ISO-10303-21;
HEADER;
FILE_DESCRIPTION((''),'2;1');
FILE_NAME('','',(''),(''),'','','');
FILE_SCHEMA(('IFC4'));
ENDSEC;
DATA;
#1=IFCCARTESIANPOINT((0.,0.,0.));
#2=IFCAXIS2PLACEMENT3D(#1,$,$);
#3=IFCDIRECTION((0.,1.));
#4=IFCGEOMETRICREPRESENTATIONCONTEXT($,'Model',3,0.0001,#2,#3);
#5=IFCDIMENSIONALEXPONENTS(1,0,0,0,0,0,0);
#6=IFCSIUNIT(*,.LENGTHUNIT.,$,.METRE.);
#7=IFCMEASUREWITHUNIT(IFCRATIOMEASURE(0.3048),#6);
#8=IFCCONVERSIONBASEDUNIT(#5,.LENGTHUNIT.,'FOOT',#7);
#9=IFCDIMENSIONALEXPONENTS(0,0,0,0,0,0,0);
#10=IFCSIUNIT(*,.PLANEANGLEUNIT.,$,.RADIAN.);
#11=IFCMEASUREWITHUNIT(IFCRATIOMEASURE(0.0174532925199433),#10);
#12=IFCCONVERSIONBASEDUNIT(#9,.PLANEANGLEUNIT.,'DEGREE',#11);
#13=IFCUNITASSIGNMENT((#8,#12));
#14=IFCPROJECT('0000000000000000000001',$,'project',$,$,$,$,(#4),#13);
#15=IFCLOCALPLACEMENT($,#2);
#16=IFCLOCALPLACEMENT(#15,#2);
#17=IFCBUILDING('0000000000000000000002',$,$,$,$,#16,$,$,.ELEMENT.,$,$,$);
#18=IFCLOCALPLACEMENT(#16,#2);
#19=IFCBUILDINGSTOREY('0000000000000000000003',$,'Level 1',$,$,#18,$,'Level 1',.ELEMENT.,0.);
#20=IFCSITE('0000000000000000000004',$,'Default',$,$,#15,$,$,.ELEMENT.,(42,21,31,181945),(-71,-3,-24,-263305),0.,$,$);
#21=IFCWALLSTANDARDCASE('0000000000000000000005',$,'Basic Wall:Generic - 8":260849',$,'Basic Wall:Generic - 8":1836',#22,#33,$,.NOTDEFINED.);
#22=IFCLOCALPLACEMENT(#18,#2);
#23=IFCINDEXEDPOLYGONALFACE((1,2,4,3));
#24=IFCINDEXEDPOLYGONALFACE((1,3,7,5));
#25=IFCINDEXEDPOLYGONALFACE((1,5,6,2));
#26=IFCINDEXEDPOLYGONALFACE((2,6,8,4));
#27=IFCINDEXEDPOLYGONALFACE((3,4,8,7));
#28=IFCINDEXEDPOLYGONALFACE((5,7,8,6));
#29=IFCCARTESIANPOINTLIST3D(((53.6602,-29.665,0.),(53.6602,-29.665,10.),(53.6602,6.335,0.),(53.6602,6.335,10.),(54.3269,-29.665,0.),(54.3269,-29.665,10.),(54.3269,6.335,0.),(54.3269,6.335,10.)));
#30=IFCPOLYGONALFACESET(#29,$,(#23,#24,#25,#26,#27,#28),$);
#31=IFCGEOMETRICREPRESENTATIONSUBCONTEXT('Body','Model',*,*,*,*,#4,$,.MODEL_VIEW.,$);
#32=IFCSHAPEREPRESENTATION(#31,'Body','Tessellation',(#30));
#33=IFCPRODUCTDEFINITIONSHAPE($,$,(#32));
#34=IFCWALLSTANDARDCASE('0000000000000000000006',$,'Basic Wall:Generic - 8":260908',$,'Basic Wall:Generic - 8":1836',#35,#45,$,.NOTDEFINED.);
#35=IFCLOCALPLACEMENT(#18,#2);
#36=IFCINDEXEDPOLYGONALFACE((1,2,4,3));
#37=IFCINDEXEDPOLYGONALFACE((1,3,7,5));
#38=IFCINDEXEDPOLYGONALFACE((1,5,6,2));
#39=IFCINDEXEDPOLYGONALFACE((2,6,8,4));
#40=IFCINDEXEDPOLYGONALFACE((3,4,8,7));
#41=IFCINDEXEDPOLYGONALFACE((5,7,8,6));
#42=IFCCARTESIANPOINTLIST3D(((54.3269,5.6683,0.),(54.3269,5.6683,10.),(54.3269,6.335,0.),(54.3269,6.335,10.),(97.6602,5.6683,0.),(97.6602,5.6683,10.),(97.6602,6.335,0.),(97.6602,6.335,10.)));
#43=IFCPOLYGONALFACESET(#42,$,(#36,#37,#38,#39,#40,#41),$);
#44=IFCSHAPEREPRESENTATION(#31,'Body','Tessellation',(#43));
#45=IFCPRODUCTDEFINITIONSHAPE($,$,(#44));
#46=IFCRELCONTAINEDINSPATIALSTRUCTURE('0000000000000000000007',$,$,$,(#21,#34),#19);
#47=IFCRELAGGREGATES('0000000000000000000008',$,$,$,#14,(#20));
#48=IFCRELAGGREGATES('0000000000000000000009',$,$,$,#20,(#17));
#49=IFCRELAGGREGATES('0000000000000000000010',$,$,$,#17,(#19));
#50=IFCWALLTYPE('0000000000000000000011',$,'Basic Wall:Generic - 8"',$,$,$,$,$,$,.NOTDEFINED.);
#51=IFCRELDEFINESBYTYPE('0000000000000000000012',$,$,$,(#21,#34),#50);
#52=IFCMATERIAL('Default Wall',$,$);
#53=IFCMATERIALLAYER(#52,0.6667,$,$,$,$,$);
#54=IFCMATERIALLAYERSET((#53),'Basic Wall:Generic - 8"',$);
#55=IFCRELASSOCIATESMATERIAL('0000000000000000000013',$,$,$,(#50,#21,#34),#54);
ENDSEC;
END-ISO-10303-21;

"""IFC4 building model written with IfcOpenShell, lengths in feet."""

from ifc_helpers import new_model, entity, si_unit, converted_unit, direction, frame, frame_2d, origin, place, context, subcontext, project, spatial, rectangle, extrude, material, layer, layer_set, layer_usage, type_object, element, save


model = new_model("IFC4")

# Units and contexts
model_context = context("Model", 3, precision=0.0001, world=origin(), true_north=direction((0.0, 1.0)))
body_context = subcontext(model_context, "Body", "Model", "MODEL_VIEW")
ifc_project = project(units=[converted_unit("LENGTHUNIT", "FOOT", entity("IfcRatioMeasure", 0.3048), si_unit("LENGTHUNIT", "METRE"), dimensions=[1, 0, 0, 0, 0, 0, 0]), converted_unit("PLANEANGLEUNIT", "DEGREE", entity("IfcRatioMeasure", 0.0174532925199433), si_unit("PLANEANGLEUNIT", "RADIAN"), dimensions=[0, 0, 0, 0, 0, 0, 0])], contexts=[model_context])

# Site, building, storey
site_placement = place(None, origin())
site = spatial("IfcSite", under=ifc_project, at=site_placement, Name="Default", CompositionType="ELEMENT", RefLatitude=(42, 21, 31, 181945), RefLongitude=(-71, -3, -24, -263305), RefElevation=0.0)
building_placement = place(site_placement, origin())
building = spatial("IfcBuilding", under=site, at=building_placement, CompositionType="ELEMENT")
storey_placement = place(building_placement, origin())
storey = spatial("IfcBuildingStorey", under=building, at=storey_placement, Name="Level 1", LongName="Level 1", CompositionType="ELEMENT", Elevation=0.0)

# Walls
ifc_material_1 = material(Name="Default Wall")
ifc_layer = layer(ifc_material_1, 0.6667)
ifc_layer_set = layer_set([ifc_layer], Name="Basic Wall:Generic - 8\"")
ifc_layer_usage_1 = layer_usage(ifc_layer_set, "AXIS2", "NEGATIVE", 0.3333)
wall_type = type_object("IfcWallType", Name="Basic Wall:Generic - 8\"", PredefinedType="NOTDEFINED", material=ifc_layer_set)
wall_1_placement = place(storey_placement, frame((53.9936, 6.335, 0.0), z_axis=(0.0, 0.0, 1.0), x_axis=(0.0, -1.0, 0.0)))
element("IfcWallStandardCase", 1, at=wall_1_placement, inside=storey, type_object=wall_type, material=ifc_layer_usage_1, Name="Basic Wall:Generic - 8\":260849", ObjectType="Basic Wall:Generic - 8\":1836", PredefinedType="NOTDEFINED", context=body_context, shape_type="SweptSolid", body=[
    extrude(rectangle(XDim=36.0, YDim=0.6667, at=frame_2d((18.0, 0.0), x_axis=(-1.0, 0.0))), origin(), (0.0, 0.0, 1.0), 10.0),
])
ifc_layer_usage_2 = layer_usage(ifc_layer_set, "AXIS2", "NEGATIVE", 0.3333)
wall_2_placement = place(storey_placement, frame((54.3269, 6.0017, 0.0)))
element("IfcWallStandardCase", 2, at=wall_2_placement, inside=storey, type_object=wall_type, material=ifc_layer_usage_2, Name="Basic Wall:Generic - 8\":260908", ObjectType="Basic Wall:Generic - 8\":1836", PredefinedType="NOTDEFINED", context=body_context, shape_type="SweptSolid", body=[
    extrude(rectangle(XDim=43.3333, YDim=0.6667, at=frame_2d((21.6667, 0.0), x_axis=(-1.0, 0.0))), origin(), (0.0, 0.0, 1.0), 10.0),
])

save(model, "model.ifc")
